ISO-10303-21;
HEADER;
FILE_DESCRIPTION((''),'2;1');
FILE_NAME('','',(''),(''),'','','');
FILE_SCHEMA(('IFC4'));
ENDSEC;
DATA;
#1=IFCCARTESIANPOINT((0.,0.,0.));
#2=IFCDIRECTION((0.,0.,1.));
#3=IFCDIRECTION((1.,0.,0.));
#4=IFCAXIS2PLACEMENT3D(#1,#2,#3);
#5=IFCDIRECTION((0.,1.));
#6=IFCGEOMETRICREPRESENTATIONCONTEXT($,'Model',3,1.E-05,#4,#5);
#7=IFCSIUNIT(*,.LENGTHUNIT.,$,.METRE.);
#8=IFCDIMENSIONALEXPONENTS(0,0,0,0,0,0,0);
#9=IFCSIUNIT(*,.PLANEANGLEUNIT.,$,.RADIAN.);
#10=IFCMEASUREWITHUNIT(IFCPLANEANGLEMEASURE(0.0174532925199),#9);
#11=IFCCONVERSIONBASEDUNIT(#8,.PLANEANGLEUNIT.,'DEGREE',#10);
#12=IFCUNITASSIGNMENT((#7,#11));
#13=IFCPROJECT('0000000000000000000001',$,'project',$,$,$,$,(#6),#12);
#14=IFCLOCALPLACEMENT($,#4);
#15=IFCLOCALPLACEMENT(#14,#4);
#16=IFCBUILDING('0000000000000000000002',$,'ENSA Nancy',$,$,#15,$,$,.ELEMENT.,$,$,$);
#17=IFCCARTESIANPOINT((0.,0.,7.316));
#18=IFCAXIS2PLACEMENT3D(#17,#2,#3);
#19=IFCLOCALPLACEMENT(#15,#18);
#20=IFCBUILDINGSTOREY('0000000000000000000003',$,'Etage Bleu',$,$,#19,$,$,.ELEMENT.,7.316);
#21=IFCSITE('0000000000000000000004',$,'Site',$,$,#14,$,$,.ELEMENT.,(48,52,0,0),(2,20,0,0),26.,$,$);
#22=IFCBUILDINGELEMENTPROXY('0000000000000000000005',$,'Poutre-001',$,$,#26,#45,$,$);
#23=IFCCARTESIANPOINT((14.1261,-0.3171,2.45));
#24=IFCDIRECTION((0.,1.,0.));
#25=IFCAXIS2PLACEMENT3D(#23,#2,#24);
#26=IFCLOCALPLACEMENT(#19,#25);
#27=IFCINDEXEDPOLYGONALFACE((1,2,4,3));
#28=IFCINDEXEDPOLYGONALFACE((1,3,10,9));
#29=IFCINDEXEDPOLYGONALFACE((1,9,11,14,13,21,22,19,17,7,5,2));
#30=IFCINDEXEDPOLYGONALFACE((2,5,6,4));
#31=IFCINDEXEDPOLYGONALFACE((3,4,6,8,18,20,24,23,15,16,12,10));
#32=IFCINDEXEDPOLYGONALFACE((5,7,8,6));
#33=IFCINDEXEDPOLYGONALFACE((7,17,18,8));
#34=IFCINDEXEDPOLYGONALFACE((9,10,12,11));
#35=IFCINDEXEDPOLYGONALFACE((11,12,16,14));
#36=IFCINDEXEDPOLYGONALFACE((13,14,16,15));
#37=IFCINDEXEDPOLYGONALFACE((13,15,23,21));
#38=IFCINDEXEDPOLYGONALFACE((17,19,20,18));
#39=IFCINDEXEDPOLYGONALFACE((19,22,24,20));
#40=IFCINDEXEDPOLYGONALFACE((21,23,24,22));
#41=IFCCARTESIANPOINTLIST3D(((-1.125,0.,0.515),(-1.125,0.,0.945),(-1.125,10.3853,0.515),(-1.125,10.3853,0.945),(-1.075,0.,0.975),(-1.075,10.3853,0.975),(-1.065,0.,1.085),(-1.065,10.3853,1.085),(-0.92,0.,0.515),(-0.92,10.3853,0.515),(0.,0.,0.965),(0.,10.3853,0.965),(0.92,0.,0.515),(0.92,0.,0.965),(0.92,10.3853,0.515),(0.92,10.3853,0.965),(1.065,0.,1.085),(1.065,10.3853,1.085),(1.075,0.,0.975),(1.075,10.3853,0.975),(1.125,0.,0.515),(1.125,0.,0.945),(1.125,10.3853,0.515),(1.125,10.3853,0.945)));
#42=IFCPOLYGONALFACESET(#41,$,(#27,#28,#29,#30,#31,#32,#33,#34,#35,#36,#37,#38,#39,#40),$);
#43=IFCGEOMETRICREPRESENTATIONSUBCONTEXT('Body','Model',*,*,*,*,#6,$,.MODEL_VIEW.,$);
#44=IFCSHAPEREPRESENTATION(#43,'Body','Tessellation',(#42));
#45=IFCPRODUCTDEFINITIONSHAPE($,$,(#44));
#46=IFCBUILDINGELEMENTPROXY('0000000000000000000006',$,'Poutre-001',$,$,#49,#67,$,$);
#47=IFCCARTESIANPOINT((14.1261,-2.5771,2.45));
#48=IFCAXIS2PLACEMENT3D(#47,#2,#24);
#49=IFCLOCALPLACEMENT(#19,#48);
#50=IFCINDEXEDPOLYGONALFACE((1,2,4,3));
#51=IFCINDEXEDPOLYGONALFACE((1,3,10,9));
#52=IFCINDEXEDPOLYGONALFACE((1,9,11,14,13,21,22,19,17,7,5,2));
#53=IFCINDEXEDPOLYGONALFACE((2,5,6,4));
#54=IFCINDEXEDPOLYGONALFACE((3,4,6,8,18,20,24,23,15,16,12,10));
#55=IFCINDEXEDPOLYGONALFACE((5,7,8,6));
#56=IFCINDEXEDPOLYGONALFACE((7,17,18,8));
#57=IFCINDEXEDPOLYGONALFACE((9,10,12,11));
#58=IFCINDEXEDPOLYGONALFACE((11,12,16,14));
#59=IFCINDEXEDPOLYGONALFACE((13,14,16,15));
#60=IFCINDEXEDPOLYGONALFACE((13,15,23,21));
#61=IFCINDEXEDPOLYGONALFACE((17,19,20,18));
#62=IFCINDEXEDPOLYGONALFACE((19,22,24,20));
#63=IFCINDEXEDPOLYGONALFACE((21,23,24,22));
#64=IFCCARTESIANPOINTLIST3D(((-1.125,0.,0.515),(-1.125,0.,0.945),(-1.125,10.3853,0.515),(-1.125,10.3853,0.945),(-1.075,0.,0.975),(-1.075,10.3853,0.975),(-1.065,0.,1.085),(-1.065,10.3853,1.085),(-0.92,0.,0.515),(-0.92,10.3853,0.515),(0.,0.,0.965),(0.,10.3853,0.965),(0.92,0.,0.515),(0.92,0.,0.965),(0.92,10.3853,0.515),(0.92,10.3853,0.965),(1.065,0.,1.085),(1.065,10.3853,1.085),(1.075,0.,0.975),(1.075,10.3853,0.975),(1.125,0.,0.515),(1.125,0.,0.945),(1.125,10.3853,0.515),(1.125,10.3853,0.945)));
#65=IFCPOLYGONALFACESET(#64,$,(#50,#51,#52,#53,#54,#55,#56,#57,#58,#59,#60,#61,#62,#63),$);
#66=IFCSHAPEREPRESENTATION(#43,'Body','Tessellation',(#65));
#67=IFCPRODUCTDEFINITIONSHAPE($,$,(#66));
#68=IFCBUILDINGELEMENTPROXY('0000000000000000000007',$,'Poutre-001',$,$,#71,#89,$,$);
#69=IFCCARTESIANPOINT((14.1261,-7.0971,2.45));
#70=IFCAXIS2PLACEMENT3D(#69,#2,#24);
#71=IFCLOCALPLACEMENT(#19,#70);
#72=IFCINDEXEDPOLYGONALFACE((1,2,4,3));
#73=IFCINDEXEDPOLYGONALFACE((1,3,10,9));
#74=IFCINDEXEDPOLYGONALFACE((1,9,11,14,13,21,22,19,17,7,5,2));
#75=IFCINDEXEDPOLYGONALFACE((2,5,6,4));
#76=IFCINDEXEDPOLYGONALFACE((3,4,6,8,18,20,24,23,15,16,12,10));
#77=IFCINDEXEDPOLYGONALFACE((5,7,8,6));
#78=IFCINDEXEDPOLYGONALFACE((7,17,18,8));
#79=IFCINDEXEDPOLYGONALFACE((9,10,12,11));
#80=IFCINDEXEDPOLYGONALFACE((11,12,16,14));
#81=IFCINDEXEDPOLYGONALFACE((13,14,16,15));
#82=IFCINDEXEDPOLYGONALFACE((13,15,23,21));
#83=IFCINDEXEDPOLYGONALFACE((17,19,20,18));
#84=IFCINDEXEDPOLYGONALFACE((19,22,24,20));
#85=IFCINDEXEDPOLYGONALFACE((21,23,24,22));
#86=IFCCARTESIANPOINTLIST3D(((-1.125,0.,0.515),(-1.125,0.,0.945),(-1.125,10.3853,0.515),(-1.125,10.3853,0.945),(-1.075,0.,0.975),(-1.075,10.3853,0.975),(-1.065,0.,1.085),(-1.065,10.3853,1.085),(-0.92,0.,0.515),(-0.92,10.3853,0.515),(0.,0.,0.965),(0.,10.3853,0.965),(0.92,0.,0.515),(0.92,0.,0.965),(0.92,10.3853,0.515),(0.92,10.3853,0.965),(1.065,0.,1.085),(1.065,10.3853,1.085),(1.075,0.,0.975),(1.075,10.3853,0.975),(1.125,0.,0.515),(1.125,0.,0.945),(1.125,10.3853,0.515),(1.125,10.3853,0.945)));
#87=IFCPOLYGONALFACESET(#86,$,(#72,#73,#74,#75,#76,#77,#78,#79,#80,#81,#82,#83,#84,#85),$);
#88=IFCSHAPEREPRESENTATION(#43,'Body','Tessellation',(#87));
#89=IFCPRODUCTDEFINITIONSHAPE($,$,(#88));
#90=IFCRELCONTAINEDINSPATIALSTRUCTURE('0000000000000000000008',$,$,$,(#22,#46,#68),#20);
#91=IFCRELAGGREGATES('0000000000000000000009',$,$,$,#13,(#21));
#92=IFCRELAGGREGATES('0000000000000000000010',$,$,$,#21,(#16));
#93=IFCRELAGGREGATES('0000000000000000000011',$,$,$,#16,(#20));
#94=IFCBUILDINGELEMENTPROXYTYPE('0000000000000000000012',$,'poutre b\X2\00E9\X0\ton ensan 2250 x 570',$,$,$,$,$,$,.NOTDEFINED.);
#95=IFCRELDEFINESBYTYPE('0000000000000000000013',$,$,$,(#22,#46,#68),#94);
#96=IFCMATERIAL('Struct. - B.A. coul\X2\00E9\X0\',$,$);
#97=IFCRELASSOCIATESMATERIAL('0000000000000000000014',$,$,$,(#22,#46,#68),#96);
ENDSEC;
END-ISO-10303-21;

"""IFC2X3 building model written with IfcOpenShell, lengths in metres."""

from ifc_helpers import new_model, entity, si_unit, converted_unit, direction, frame, origin_with_axes, place, context, subcontext, project, spatial, polyline, outline, extrude, material, type_object, element, save


model = new_model("IFC2X3")

# Units and contexts
model_context = context("Model", 3, precision=1e-05, world=origin_with_axes(), true_north=direction((0.0, 1.0)))
body_context = subcontext(model_context, "Body", "Model", "MODEL_VIEW")
ifc_project = project(units=[si_unit("LENGTHUNIT", "METRE"), converted_unit("PLANEANGLEUNIT", "DEGREE", entity("IfcPlaneAngleMeasure", 0.0174532925199), si_unit("PLANEANGLEUNIT", "RADIAN"), dimensions=[0, 0, 0, 0, 0, 0, 0])], contexts=[model_context])

# Site, building, storey
site_placement = place(None, origin_with_axes())
site = spatial("IfcSite", under=ifc_project, at=site_placement, Name="Site", CompositionType="ELEMENT", RefLatitude=(48, 52, 0, 0), RefLongitude=(2, 20, 0, 0), RefElevation=26.0)
building_placement = place(site_placement, origin_with_axes())
building = spatial("IfcBuilding", under=site, at=building_placement, Name="ENSA Nancy", CompositionType="ELEMENT")
storey_placement = place(building_placement, frame((0.0, 0.0, 7.316), z_axis=(0.0, 0.0, 1.0), x_axis=(1.0, 0.0, 0.0)))
storey = spatial("IfcBuildingStorey", under=building, at=storey_placement, Name="Etage Bleu", CompositionType="ELEMENT", Elevation=7.316)

# Building element proxies
ifc_material = material(Name="Struct. - B.A. coulé")
building_element_proxy_type = type_object("IfcBuildingElementProxyType", Name="poutre béton ensan 2250 x 570", PredefinedType="NOTDEFINED")
for number, where, z_axis, x_axis, name in (
    (1, (14.1261, -0.3171, 2.45), (0.0, 0.0, 1.0), (0.0, 1.0, 0.0), "Poutre-001"),
    (2, (14.1261, -2.5771, 2.45), (0.0, 0.0, 1.0), (0.0, 1.0, 0.0), "Poutre-001"),
    (3, (14.1261, -7.0971, 2.45), (0.0, 0.0, 1.0), (0.0, 1.0, 0.0), "Poutre-001"),
):
    element("IfcBuildingElementProxy", number, at=place(storey_placement, frame(where, z_axis=z_axis, x_axis=x_axis)), inside=storey, type_object=building_element_proxy_type, material=ifc_material, Name=name, context=body_context, shape_type="SweptSolid", body=[
        extrude(outline(polyline([(-1.065, 1.085), (-1.075, 0.975), (-1.125, 0.945), (-1.125, 0.515), (-0.92, 0.515), (0.0, 0.965), (0.92, 0.965), (0.92, 0.515), (1.125, 0.515), (1.125, 0.945), (1.075, 0.975), (1.065, 1.085), (-1.065, 1.085)])), frame((0.0, 10.3853, 0.0), z_axis=(0.0, -1.0, 0.0), x_axis=(1.0, 0.0, 0.0)), (0.0, 0.0, 1.0), 10.3853),
    ])

save(model, "model.ifc")
